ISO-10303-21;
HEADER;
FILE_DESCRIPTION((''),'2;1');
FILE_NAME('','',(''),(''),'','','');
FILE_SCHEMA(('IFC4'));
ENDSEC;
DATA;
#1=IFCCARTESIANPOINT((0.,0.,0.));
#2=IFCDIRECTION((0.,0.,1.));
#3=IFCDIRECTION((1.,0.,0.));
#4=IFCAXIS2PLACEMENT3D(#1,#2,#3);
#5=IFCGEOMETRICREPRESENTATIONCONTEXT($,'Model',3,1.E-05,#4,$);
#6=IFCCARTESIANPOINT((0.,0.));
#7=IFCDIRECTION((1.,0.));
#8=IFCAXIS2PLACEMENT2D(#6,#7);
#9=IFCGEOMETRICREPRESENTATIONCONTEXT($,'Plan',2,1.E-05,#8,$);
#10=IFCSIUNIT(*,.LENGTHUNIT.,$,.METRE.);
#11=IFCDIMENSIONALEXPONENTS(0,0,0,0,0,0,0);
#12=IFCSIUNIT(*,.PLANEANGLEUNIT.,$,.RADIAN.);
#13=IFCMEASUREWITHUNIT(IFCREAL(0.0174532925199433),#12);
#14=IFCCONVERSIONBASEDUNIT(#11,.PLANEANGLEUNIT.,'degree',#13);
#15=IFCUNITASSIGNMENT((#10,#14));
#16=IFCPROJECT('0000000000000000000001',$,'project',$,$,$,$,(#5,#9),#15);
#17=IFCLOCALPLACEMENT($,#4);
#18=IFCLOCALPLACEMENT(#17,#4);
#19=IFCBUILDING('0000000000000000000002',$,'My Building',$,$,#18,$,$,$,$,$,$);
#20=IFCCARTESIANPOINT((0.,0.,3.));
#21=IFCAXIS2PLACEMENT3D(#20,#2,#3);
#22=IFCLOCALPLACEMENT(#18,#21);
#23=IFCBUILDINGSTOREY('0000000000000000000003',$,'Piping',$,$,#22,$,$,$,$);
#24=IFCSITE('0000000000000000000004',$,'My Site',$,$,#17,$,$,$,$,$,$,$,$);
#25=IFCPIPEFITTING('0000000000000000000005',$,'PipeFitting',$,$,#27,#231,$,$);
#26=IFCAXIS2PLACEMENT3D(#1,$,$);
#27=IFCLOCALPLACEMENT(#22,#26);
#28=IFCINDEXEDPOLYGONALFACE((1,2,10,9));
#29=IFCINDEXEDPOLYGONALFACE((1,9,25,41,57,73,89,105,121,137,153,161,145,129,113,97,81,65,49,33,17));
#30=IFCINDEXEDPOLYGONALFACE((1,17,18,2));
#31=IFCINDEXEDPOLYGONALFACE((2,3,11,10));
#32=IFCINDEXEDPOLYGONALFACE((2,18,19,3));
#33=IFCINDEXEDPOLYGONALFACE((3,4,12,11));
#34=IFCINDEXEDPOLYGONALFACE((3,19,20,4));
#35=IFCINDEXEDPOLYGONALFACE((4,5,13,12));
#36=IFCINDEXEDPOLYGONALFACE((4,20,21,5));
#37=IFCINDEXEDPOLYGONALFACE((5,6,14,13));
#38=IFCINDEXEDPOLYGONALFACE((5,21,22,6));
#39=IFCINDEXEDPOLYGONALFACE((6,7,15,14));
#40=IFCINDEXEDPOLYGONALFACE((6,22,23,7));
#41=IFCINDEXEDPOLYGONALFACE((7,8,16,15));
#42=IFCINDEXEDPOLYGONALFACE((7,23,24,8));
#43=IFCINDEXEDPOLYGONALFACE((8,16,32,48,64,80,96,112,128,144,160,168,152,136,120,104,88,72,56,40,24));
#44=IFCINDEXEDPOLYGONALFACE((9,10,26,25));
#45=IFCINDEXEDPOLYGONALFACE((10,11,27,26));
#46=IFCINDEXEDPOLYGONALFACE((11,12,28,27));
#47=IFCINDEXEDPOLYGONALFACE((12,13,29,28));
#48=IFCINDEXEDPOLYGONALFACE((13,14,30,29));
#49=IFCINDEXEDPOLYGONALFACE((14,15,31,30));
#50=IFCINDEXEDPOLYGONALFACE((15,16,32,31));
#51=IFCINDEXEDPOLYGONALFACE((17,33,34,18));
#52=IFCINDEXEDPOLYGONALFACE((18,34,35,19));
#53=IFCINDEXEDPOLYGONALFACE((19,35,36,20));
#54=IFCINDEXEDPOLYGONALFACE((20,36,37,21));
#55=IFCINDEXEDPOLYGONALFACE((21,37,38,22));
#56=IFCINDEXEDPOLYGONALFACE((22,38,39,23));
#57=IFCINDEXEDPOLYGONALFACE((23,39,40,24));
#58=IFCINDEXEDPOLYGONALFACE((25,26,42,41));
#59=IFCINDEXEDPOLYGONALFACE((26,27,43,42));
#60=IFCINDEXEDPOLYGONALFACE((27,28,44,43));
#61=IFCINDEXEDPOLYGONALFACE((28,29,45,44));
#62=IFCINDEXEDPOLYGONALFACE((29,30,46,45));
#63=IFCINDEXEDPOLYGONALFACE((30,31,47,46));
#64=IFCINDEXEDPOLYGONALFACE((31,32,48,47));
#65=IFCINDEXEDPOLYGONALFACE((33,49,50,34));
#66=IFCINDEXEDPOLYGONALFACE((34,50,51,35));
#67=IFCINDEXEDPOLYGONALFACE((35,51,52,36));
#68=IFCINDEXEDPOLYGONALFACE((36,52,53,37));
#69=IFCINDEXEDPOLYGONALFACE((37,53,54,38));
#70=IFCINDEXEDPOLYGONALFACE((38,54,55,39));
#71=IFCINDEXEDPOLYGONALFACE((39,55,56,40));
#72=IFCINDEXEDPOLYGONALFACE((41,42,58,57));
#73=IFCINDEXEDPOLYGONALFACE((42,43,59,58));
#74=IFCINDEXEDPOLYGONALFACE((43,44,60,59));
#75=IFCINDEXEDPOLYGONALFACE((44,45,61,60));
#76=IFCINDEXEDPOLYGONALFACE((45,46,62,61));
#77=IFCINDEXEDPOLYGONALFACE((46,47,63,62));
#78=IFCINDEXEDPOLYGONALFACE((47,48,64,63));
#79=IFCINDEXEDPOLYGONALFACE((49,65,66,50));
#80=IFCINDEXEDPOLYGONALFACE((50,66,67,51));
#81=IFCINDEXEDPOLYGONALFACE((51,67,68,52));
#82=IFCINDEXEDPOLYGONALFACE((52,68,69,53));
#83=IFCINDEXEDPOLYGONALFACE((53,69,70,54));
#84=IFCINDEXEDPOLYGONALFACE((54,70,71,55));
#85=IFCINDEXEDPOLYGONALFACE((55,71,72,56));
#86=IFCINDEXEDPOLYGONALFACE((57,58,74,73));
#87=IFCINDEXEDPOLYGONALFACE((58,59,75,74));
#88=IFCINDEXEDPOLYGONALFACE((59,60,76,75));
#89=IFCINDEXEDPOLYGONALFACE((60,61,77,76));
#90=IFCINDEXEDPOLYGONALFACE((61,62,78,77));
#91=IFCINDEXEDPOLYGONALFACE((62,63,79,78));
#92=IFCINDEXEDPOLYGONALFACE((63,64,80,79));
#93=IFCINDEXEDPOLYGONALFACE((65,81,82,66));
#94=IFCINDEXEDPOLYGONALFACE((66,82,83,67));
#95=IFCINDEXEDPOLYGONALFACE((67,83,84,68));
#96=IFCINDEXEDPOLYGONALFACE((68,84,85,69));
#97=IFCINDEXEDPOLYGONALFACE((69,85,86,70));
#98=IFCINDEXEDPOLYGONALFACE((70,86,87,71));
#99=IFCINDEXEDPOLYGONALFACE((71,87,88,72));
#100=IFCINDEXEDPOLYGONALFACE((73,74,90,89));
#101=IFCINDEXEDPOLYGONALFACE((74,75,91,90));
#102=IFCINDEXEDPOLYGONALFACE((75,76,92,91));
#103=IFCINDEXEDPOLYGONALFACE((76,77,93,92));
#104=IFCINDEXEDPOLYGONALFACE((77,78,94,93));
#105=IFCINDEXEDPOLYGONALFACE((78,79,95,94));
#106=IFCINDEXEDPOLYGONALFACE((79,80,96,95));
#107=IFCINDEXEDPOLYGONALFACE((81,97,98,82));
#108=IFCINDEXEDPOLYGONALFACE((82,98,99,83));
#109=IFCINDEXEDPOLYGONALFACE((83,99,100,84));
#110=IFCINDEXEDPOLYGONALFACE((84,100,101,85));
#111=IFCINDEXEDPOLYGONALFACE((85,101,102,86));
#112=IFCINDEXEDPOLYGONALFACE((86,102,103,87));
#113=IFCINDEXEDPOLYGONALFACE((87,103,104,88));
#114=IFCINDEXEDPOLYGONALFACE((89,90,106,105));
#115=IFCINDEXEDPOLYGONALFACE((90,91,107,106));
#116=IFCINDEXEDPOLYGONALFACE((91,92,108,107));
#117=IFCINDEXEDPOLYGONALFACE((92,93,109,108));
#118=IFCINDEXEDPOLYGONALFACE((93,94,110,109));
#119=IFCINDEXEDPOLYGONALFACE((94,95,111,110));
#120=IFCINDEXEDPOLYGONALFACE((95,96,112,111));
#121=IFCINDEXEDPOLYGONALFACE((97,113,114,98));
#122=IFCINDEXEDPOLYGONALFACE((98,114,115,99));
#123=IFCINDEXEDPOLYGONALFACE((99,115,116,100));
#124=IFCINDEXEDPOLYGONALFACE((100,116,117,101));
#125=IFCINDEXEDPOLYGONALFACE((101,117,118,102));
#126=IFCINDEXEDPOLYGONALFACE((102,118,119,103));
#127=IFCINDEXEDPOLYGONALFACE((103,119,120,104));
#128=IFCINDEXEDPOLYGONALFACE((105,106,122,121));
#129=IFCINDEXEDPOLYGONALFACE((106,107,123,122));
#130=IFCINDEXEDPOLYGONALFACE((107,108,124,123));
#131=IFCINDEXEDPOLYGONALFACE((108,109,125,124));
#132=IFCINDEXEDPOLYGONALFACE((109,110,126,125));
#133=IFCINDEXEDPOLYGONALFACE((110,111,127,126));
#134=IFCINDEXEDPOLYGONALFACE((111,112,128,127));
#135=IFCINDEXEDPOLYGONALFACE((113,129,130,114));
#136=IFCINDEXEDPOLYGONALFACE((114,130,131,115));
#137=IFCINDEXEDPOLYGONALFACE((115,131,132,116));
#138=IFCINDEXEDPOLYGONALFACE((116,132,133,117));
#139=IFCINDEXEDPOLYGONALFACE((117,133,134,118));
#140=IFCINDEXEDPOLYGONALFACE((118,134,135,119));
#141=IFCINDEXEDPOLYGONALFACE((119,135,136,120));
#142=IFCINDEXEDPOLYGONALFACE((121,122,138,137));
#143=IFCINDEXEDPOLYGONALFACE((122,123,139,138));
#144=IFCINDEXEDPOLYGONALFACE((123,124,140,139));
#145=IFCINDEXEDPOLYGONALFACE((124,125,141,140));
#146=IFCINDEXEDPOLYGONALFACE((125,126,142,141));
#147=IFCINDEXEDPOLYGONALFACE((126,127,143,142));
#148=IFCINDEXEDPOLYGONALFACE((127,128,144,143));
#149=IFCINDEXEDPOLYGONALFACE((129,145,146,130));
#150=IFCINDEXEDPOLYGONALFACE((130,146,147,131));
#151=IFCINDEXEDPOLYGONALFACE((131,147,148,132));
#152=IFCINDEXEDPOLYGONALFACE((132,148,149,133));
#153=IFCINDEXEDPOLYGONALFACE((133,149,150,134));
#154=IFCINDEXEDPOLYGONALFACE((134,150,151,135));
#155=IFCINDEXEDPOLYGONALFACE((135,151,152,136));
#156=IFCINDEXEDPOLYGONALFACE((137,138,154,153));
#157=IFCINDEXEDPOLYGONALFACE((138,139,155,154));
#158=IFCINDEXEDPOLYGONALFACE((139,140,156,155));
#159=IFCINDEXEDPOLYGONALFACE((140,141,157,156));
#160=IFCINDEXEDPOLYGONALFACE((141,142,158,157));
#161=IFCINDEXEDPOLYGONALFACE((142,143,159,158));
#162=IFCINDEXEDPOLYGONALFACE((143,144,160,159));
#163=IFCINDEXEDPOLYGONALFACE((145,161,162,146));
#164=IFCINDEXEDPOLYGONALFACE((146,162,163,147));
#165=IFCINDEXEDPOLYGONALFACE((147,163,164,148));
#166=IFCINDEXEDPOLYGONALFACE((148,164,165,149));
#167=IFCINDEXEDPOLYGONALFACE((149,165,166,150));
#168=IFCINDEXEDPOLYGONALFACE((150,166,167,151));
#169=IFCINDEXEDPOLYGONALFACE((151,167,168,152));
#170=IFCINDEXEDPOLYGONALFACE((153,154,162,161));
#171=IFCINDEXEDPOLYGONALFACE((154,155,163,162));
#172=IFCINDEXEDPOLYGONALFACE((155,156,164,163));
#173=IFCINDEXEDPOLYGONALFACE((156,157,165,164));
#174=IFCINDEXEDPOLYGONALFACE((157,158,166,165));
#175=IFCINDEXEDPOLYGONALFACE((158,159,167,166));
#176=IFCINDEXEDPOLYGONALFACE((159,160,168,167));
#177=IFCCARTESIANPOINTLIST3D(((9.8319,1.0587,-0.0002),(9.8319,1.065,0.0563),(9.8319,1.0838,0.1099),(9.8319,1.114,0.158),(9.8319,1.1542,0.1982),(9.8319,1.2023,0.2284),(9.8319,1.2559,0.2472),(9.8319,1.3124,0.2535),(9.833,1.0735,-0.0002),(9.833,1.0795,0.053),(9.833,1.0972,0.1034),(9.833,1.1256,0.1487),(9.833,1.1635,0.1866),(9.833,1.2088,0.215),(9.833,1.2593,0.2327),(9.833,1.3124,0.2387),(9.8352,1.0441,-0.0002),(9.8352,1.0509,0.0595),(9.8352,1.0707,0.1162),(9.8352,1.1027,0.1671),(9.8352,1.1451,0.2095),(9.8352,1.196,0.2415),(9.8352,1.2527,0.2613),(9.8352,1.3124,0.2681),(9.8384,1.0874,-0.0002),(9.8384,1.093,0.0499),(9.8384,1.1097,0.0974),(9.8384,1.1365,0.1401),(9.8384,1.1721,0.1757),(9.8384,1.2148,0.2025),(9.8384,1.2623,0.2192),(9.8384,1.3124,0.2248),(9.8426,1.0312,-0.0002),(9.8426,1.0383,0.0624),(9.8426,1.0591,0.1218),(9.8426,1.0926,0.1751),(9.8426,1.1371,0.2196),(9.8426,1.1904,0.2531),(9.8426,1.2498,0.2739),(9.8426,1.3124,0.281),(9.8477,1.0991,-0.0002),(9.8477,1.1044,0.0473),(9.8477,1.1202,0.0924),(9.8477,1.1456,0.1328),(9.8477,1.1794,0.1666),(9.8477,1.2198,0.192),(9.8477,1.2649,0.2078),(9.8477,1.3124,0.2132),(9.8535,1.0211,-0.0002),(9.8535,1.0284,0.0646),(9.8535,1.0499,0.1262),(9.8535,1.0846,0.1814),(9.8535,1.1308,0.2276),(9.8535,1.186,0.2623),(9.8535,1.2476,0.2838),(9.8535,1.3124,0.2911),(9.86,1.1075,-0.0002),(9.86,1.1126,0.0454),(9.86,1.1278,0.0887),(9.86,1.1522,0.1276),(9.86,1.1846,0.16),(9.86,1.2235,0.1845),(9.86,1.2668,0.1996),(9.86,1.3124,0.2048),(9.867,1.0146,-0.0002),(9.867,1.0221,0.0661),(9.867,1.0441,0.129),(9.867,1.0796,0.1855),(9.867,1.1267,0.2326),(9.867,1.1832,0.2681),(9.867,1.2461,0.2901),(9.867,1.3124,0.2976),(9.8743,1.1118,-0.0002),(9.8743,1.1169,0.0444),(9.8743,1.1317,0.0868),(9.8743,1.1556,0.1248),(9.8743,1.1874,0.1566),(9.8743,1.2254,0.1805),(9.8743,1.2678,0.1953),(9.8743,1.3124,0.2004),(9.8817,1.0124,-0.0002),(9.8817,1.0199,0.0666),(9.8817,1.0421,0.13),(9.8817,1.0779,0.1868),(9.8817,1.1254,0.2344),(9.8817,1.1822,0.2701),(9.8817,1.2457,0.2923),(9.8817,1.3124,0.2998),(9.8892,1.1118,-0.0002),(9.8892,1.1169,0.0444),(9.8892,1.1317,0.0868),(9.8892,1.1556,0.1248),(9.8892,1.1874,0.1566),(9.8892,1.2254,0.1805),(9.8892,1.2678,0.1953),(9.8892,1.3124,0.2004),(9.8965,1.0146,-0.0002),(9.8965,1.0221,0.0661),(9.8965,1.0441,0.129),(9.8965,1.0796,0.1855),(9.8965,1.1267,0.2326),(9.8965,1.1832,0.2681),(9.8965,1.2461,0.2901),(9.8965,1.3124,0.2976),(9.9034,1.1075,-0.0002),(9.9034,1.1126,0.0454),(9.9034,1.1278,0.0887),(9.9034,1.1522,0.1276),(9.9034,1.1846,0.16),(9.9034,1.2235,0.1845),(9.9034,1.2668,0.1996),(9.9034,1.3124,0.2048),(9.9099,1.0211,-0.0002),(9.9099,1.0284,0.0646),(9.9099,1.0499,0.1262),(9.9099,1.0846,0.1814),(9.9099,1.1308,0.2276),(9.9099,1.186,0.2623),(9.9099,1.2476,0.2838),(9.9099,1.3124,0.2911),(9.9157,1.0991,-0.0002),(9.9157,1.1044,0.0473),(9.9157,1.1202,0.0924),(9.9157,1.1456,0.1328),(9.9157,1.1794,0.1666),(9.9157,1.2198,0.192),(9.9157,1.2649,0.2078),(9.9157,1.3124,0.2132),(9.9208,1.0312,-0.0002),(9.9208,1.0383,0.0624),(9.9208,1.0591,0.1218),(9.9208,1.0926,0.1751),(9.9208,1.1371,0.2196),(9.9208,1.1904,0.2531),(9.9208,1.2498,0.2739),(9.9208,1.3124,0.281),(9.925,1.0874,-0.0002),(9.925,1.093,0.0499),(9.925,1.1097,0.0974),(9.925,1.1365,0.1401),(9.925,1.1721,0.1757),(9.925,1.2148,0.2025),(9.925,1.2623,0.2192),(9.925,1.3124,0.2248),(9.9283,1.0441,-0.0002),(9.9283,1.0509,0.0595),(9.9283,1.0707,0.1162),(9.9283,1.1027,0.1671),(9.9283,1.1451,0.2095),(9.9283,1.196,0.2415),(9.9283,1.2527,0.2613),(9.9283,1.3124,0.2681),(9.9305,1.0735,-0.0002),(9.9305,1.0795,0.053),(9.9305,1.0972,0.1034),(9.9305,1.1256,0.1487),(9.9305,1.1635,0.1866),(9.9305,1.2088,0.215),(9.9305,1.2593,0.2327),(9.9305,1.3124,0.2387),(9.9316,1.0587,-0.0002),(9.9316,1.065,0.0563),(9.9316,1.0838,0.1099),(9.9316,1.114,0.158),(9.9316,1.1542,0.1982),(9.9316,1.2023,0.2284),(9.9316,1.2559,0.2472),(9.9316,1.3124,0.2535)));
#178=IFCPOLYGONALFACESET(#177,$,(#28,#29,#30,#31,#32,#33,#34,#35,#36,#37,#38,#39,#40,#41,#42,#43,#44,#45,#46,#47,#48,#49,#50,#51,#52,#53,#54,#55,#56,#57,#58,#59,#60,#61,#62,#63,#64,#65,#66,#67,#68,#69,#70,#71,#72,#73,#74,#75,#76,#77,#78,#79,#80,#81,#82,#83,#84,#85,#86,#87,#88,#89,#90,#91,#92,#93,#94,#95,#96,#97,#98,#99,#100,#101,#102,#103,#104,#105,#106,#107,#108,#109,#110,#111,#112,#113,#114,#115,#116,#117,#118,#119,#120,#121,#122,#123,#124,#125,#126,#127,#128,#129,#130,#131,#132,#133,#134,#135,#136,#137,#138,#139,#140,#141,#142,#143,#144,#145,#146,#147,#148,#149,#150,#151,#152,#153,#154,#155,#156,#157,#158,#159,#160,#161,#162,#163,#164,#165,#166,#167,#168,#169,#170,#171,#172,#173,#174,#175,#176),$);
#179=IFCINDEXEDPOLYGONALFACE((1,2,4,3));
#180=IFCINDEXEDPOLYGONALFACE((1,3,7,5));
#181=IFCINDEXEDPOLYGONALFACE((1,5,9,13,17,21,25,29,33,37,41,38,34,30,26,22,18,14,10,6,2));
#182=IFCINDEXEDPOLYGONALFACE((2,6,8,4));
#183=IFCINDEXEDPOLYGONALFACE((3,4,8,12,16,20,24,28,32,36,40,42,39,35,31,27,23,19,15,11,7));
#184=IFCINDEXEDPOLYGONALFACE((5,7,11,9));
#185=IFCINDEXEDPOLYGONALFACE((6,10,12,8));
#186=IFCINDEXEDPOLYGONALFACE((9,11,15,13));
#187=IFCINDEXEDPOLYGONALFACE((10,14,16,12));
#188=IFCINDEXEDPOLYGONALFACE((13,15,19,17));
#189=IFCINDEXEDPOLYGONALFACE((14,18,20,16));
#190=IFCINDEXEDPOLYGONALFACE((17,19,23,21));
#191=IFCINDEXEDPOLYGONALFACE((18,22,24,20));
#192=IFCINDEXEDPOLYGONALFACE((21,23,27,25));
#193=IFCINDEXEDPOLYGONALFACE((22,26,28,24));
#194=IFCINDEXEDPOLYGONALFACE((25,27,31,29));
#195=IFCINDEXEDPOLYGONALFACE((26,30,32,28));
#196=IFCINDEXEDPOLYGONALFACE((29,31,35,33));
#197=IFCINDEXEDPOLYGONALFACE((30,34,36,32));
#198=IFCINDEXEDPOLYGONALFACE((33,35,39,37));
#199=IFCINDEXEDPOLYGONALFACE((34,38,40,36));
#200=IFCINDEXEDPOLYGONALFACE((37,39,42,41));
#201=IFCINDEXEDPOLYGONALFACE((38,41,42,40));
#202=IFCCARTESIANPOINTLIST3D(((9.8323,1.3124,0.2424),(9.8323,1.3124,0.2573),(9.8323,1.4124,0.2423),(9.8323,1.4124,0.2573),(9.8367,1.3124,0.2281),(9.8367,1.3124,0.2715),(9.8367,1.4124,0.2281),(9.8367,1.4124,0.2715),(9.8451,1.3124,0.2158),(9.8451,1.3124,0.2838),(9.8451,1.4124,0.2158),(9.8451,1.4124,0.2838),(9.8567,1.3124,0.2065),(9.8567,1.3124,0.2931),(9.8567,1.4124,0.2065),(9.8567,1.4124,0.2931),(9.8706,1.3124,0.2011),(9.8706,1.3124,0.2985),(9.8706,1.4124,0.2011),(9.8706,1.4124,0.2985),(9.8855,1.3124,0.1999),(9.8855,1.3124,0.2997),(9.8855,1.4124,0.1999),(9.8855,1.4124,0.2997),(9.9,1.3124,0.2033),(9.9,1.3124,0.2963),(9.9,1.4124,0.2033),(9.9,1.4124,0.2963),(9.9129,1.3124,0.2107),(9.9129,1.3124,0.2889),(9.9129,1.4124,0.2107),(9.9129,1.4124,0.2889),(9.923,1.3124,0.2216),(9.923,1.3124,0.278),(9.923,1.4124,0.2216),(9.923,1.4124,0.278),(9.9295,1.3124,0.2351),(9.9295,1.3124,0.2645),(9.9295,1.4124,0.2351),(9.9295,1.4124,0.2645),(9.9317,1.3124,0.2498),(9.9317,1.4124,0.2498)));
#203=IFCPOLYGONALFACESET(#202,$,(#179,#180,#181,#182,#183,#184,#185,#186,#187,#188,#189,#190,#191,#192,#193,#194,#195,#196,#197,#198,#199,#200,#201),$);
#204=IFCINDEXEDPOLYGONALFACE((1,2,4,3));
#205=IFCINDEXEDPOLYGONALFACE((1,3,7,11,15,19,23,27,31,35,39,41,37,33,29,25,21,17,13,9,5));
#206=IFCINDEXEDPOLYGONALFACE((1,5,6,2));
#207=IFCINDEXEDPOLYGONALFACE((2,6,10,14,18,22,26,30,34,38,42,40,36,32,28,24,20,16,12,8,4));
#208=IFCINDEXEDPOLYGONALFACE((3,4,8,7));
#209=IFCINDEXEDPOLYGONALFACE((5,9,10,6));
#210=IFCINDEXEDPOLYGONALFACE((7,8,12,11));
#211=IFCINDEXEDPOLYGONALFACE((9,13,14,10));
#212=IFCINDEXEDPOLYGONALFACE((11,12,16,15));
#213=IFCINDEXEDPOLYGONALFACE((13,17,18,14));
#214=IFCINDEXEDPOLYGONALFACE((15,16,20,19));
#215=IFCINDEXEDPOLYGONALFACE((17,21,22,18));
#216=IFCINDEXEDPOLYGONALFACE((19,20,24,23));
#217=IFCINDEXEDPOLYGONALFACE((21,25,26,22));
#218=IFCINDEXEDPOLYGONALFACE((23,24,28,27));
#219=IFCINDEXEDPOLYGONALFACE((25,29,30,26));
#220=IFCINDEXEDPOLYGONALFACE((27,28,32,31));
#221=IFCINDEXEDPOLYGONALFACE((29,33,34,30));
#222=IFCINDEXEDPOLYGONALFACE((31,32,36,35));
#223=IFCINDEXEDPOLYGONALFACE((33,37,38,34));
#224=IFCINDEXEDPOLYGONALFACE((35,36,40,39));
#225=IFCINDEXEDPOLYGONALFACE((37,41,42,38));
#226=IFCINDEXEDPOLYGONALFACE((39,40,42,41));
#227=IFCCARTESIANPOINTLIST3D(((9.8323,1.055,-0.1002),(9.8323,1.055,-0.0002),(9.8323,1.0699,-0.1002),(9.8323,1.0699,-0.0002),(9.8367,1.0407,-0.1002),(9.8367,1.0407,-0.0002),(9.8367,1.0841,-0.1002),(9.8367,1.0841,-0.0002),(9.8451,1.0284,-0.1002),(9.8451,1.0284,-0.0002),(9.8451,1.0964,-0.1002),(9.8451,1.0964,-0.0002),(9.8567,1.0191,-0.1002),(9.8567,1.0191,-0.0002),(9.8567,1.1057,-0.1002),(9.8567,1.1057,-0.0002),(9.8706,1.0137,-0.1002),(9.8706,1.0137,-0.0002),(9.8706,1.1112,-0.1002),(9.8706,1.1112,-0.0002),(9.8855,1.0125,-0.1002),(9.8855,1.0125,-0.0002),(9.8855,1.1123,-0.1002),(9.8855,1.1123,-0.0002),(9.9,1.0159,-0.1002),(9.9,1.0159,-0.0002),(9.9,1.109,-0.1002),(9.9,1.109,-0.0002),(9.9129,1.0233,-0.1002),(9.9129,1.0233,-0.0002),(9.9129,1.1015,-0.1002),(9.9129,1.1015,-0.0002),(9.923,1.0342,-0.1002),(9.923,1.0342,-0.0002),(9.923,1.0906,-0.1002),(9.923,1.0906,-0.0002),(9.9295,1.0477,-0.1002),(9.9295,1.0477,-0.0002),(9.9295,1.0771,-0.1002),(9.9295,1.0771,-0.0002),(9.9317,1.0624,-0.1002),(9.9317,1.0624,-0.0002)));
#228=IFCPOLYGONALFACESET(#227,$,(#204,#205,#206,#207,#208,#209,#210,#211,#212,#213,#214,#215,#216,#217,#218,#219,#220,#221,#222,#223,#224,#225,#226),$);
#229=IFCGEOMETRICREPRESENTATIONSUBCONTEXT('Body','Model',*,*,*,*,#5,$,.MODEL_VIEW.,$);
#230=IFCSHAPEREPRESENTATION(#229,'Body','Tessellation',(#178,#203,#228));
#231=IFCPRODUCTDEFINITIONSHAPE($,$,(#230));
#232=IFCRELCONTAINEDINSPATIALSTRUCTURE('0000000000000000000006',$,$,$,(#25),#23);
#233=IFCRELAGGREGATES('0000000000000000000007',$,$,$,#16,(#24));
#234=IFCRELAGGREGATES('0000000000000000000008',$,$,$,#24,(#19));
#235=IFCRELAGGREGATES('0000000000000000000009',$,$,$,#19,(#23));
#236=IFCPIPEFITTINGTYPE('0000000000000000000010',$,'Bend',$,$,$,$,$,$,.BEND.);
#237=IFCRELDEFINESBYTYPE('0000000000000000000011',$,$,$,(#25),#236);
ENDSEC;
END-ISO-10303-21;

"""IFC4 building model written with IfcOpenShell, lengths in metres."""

from ifc_helpers import new_model, entity, si_unit, converted_unit, frame, origin_with_axes, origin_2d_with_axis, place, context, subcontext, project, spatial, circle, extrude, source, transform, mapped, type_object, type_shapes, element, save


model = new_model("IFC4")

# Units and contexts
model_context = context("Model", 3, precision=1e-05, world=origin_with_axes())
plan_context = context("Plan", 2, precision=1e-05, world=origin_2d_with_axis())
body_context = subcontext(model_context, "Body", "Model", "MODEL_VIEW")
ifc_project = project(units=[si_unit("LENGTHUNIT", "METRE"), converted_unit("PLANEANGLEUNIT", "degree", entity("IfcReal", 0.0174532925199433), si_unit("PLANEANGLEUNIT", "RADIAN"), dimensions=[0, 0, 0, 0, 0, 0, 0])], contexts=[model_context, plan_context])

# Site, building, storey
site_placement = place(None, origin_with_axes())
site = spatial("IfcSite", under=ifc_project, at=site_placement, Name="My Site")
building_placement = place(site_placement, origin_with_axes())
building = spatial("IfcBuilding", under=site, at=building_placement, Name="My Building")
storey_placement = place(building_placement, frame((0.0, 0.0, 3.0), z_axis=(0.0, 0.0, 1.0), x_axis=(1.0, 0.0, 0.0)))
storey = spatial("IfcBuildingStorey", under=building, at=storey_placement, Name="Piping")

# Pipe fitting
pipe_fitting_type_1 = type_object("IfcPipeFittingType", Name="Bend", PredefinedType="BEND")
shared_shape = source(origin_with_axes(), body_context, "Body", "SolidModel", [
    entity("IfcSweptDiskSolid", entity("IfcIndexedPolyCurve", entity("IfcCartesianPointList3D", [[0.0, 0.0, 0.1], [0.0, -0.0732, 0.2768], [0.0, -0.25, 0.35]]), [entity("IfcArcIndex", [1, 2, 3])]), 0.05),
    extrude(circle(Radius=0.05), origin_with_axes(), (0.0, 0.0, 1.0), 0.1),
    extrude(circle(Radius=0.05), frame((0.0, -0.25, 0.35), z_axis=(0.0, -1.0, -0.00003), x_axis=(1.0, 0.0, 0.0)), (0.0, 0.0, 1.0), 0.1),
])
type_shapes(pipe_fitting_type_1, [shared_shape])
for number, where, z_axis, x_axis, name in (
    (1, (9.8817, 1.4124, 0.2498), (0.0, -1.0, 0.000008), (1.0, 0.0, 0.0), "PipeFitting"),
):
    element("IfcPipeFitting", number, at=place(storey_placement, frame(where, z_axis=z_axis, x_axis=x_axis)), inside=storey, type_object=pipe_fitting_type_1, Name=name, context=body_context, shape_type="MappedRepresentation", body=[
        mapped(shared_shape, transform((0.0, 0.0, 0.0), x_axis=(1.0, 0.0, 0.0), y_axis=(0.0, 1.0, 0.0), z_axis=(0.0, 0.0, 1.0), scale=1.0)),
    ])

save(model, "model.ifc")
